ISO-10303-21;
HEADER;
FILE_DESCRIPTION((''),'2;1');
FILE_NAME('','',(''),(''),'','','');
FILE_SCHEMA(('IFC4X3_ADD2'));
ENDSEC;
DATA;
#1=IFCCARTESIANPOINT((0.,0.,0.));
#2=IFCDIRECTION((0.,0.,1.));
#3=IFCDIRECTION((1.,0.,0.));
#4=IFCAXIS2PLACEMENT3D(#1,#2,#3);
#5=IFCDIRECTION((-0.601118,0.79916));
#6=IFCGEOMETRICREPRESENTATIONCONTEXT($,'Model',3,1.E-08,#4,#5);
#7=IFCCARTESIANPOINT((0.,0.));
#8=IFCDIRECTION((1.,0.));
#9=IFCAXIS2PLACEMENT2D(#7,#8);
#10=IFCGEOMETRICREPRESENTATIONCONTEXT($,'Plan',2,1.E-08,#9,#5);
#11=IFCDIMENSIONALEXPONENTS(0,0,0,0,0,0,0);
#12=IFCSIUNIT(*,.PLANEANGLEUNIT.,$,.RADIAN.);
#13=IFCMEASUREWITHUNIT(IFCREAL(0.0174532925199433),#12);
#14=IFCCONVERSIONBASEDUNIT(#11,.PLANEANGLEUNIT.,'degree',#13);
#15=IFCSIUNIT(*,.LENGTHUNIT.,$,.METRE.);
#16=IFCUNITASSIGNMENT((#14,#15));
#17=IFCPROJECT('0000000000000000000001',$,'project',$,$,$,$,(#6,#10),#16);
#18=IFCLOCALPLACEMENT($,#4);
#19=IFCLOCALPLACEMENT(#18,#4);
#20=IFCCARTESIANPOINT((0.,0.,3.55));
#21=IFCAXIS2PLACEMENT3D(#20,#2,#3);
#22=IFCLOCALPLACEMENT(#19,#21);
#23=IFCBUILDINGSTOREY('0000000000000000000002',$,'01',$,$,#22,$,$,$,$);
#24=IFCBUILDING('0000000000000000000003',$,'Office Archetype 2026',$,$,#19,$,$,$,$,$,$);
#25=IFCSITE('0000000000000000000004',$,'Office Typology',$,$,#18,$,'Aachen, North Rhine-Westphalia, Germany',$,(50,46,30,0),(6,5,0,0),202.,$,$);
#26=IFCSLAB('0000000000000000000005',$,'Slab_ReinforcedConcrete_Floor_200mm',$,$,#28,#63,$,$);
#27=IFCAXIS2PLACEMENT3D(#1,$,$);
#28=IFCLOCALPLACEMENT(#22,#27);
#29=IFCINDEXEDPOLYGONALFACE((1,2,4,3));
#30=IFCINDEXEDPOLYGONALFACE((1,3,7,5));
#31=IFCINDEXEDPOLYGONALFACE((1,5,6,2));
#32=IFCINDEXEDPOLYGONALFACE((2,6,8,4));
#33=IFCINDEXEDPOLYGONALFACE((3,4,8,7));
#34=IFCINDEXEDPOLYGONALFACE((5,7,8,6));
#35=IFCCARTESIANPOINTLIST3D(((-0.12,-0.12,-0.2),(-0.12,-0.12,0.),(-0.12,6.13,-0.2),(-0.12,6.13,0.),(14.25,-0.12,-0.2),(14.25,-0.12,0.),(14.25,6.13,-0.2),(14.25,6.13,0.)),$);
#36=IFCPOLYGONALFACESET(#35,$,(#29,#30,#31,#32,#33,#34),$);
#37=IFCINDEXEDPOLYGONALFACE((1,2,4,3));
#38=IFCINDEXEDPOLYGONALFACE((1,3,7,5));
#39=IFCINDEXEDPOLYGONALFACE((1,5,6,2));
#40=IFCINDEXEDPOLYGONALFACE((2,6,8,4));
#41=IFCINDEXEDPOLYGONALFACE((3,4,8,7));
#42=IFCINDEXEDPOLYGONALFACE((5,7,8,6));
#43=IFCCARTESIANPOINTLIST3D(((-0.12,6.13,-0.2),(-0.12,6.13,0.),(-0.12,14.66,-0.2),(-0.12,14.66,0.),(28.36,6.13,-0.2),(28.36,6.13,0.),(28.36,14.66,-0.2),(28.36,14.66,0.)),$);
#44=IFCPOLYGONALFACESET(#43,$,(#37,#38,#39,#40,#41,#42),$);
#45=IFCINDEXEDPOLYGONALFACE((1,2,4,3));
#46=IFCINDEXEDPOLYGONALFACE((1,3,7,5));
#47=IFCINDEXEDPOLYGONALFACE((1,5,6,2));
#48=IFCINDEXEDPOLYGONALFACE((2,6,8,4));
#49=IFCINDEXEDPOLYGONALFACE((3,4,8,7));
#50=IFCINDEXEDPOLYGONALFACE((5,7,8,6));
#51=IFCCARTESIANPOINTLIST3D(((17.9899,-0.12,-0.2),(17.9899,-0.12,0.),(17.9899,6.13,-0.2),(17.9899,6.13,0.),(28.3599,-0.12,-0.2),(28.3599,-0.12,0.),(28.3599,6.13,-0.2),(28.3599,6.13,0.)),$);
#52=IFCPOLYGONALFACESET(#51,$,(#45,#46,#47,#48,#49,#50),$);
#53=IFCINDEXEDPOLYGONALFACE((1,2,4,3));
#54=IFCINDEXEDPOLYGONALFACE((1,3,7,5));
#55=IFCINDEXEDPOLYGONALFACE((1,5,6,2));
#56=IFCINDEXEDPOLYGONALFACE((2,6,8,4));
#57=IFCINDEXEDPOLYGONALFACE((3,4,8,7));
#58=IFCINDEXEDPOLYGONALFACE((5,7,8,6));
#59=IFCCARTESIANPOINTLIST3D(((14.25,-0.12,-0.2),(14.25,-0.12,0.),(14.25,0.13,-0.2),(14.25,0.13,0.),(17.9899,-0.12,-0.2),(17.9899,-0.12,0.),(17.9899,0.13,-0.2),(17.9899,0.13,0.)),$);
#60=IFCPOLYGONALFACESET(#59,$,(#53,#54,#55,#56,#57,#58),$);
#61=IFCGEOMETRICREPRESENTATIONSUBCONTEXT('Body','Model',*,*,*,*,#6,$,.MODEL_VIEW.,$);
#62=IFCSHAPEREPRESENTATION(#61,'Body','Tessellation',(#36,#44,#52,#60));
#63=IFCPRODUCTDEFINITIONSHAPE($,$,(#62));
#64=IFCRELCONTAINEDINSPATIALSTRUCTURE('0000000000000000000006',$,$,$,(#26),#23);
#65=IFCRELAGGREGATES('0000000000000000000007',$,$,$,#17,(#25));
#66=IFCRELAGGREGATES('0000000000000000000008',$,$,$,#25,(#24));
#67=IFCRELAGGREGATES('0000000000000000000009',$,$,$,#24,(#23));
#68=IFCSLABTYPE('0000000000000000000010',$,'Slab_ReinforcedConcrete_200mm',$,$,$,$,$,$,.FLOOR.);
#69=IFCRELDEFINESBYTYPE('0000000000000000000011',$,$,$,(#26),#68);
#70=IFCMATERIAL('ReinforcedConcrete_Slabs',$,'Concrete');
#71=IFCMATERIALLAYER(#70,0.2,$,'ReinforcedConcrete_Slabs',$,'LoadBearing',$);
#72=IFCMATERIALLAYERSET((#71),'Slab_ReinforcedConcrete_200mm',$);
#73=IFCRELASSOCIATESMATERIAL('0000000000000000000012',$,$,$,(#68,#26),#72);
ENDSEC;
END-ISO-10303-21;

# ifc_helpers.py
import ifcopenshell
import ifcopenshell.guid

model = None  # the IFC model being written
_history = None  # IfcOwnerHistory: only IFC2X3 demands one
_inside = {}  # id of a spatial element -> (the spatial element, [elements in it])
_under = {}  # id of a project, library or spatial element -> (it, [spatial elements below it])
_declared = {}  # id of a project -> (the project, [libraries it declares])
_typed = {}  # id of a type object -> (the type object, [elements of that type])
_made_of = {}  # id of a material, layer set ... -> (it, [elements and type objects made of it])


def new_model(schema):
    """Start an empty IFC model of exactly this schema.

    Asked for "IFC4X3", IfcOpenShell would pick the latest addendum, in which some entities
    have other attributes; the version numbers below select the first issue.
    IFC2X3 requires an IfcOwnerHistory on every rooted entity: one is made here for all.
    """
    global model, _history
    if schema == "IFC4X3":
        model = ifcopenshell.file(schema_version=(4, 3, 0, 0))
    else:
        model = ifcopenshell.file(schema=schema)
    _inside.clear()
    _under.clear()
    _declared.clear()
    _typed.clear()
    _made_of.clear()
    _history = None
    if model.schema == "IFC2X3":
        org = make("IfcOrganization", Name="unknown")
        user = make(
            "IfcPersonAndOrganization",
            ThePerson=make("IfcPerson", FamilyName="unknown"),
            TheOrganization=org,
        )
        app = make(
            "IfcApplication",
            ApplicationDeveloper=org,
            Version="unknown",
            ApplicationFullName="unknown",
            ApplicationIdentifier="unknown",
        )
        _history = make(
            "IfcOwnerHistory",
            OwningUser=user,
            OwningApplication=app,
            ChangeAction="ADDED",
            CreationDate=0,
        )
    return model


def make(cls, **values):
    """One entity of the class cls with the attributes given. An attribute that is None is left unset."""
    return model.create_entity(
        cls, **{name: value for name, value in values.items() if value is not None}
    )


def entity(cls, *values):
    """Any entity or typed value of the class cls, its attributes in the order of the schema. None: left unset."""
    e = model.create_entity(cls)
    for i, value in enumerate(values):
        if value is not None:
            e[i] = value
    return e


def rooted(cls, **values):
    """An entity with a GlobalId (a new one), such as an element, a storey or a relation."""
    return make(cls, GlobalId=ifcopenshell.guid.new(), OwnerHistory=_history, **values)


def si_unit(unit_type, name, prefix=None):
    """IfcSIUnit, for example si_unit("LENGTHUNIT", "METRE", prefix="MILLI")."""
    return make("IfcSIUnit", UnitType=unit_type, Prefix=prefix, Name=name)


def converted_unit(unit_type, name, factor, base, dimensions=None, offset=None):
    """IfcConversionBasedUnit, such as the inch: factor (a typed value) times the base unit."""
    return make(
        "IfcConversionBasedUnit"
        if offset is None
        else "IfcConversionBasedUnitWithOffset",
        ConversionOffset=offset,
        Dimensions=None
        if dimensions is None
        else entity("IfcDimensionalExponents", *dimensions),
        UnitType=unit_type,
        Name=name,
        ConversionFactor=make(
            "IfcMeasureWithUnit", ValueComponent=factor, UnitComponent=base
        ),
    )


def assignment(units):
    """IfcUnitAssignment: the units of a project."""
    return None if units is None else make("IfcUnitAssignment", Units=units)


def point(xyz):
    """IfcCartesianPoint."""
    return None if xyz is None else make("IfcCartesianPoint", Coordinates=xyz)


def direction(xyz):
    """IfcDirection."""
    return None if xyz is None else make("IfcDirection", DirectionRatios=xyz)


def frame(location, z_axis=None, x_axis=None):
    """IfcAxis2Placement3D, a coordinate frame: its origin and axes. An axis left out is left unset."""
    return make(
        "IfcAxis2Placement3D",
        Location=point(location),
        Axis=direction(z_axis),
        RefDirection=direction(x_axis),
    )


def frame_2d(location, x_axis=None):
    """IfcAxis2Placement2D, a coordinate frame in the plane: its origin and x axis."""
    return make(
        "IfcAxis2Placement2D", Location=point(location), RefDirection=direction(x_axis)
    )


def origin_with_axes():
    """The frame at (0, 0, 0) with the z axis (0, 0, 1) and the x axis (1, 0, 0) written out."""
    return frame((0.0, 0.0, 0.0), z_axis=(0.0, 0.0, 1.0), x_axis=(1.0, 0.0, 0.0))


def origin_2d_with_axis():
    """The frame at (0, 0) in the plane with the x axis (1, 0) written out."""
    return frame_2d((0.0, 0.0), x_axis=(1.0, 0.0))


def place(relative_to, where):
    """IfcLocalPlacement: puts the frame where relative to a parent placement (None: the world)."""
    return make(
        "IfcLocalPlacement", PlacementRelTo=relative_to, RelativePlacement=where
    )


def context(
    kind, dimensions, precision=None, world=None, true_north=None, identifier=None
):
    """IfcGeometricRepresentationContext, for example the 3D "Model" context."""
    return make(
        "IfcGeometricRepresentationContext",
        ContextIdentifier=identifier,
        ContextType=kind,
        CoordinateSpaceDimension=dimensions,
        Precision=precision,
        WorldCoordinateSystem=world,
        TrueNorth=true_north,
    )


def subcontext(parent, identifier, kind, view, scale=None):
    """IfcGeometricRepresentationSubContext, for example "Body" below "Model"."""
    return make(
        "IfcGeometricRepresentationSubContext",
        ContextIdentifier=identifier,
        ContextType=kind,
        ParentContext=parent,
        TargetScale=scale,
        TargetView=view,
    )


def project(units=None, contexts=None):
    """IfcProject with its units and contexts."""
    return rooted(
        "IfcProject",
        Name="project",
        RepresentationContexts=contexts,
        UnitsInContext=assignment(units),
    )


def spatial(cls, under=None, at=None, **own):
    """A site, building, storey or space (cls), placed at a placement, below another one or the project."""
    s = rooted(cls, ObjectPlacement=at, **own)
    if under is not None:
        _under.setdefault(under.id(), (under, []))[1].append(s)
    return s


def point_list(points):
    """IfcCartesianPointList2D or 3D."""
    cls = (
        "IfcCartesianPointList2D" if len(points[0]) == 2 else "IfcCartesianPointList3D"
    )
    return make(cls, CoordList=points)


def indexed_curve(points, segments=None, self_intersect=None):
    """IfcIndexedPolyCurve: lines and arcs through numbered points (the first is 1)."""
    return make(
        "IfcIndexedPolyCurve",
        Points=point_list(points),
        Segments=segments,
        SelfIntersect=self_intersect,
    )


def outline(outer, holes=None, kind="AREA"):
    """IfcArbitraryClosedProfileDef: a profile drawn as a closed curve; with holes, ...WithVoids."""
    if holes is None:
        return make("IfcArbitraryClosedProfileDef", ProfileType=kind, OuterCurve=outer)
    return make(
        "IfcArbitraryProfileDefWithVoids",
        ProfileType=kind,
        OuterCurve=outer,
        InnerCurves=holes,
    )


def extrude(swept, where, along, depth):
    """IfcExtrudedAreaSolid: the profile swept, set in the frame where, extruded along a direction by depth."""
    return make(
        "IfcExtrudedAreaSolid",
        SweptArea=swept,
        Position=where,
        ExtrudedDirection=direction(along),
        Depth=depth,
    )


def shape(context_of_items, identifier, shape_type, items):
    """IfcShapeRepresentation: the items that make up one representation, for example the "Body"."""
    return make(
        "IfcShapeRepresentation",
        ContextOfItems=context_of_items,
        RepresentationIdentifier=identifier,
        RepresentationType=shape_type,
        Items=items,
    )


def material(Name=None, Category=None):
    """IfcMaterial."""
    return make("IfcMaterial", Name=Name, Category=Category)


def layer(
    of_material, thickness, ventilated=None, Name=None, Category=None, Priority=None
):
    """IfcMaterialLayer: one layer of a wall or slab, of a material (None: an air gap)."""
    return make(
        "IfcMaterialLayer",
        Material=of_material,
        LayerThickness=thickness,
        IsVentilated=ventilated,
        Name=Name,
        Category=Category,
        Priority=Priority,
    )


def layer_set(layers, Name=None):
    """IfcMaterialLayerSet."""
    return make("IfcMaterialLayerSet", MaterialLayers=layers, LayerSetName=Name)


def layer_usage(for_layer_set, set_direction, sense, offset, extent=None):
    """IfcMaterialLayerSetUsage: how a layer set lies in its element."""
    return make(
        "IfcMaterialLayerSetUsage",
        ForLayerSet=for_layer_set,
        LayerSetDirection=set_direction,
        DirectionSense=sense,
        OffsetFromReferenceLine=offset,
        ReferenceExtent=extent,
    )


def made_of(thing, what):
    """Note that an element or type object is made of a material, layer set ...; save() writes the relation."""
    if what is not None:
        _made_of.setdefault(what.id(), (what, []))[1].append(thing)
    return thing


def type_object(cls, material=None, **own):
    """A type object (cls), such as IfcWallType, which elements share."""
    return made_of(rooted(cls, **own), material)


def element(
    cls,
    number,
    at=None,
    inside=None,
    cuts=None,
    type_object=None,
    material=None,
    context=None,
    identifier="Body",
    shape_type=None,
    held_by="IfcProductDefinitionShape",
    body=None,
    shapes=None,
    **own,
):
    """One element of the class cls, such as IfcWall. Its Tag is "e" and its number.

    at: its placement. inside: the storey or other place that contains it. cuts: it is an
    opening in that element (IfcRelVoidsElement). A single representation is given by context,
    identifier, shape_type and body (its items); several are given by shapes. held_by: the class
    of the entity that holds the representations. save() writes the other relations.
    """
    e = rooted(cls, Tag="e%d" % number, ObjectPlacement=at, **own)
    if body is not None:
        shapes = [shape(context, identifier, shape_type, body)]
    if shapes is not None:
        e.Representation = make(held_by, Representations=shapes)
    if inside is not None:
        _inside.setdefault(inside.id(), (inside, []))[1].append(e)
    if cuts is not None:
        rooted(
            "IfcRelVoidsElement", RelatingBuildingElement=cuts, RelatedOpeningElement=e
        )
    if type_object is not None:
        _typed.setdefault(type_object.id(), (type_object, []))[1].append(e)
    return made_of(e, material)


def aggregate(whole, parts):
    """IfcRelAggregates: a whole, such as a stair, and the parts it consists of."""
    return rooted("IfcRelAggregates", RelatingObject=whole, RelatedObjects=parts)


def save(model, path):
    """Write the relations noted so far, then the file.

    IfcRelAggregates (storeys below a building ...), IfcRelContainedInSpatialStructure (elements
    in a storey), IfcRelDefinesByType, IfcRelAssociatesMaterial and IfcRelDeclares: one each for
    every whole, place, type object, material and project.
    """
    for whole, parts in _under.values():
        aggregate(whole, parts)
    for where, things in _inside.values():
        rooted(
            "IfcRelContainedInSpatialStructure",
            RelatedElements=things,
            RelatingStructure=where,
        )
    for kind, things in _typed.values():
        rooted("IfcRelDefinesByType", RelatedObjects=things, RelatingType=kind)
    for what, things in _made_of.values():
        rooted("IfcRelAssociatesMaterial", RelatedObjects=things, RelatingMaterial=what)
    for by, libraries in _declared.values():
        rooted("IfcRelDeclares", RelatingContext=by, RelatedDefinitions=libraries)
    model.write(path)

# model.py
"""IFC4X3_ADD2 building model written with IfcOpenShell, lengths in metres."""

from ifc_helpers import new_model, entity, si_unit, converted_unit, direction, frame, origin_with_axes, origin_2d_with_axis, place, context, subcontext, project, spatial, indexed_curve, outline, extrude, material, layer, layer_set, layer_usage, type_object, element, save


model = new_model("IFC4X3_ADD2")

# Units and contexts
model_context = context("Model", 3, precision=1e-08, world=origin_with_axes(), true_north=direction((-0.601118, 0.79916)))
plan_context = context("Plan", 2, precision=1e-08, world=origin_2d_with_axis(), true_north=direction((-0.601118, 0.79916)))
body_context = subcontext(model_context, "Body", "Model", "MODEL_VIEW")
ifc_project = project(units=[converted_unit("PLANEANGLEUNIT", "degree", entity("IfcReal", 0.0174532925199433), si_unit("PLANEANGLEUNIT", "RADIAN"), dimensions=[0, 0, 0, 0, 0, 0, 0]), si_unit("LENGTHUNIT", "METRE")], contexts=[model_context, plan_context])

# Site, building, storey
site_placement = place(None, origin_with_axes())
site = spatial("IfcSite", under=ifc_project, at=site_placement, Name="Office Typology", LongName="Aachen, North Rhine-Westphalia, Germany", RefLatitude=(50, 46, 30, 0), RefLongitude=(6, 5, 0, 0), RefElevation=202.0)
building_placement = place(site_placement, origin_with_axes())
building = spatial("IfcBuilding", under=site, at=building_placement, Name="Office Archetype 2026")
storey_placement = place(building_placement, frame((0.0, 0.0, 3.55), z_axis=(0.0, 0.0, 1.0), x_axis=(1.0, 0.0, 0.0)))
storey = spatial("IfcBuildingStorey", under=building, at=storey_placement, Name="01")

# Slab
ifc_material_1 = material(Name="ReinforcedConcrete_Slabs", Category="Concrete")
ifc_layer_1 = layer(ifc_material_1, 0.2, Name="ReinforcedConcrete_Slabs", Category="LoadBearing")
ifc_layer_set_1 = layer_set([ifc_layer_1], Name="Slab_ReinforcedConcrete_200mm")
slab_type_1 = type_object("IfcSlabType", Name="Slab_ReinforcedConcrete_200mm", PredefinedType="FLOOR", material=ifc_layer_set_1)
ifc_layer_usage_1 = layer_usage(ifc_layer_set_1, "AXIS3", "POSITIVE", 0.0)
slab_1_placement = place(storey_placement, frame((17.9899, 6.13, 0.0), z_axis=(0.0, 0.0, 1.0), x_axis=(1.0, 0.0, 0.0)))
element("IfcSlab", 1, at=slab_1_placement, inside=storey, type_object=slab_type_1, material=ifc_layer_usage_1, Name="Slab_ReinforcedConcrete_Floor_200mm", context=body_context, shape_type="SweptSolid", body=[
    extrude(outline(indexed_curve([(0.0, -6.25), (14.37, -6.25), (14.37, 0.0), (0.0, 0.0), (0.0, -6.25)])), frame((-18.1099, 0.0, -0.2), z_axis=(0.0, 0.0, 1.0), x_axis=(1.0, 0.0, 0.0)), (0.0, 0.0, 1.0), 0.2),
    extrude(outline(indexed_curve([(0.0, 0.0), (28.48, 0.0), (28.48, -8.53), (0.0, -8.53), (0.0, 0.0)])), frame((-18.1099, 8.53, -0.2), z_axis=(0.0, 0.0, 1.0), x_axis=(1.0, 0.0, 0.0)), (0.0, 0.0, 1.0), 0.2),
    extrude(outline(indexed_curve([(0.0, 0.0), (0.0, -6.25), (10.37, -6.25), (10.37, 0.0), (0.0, 0.0)])), frame((0.0, 0.0, -0.2), z_axis=(0.0, 0.0, 1.0), x_axis=(1.0, 0.0, 0.0)), (0.0, 0.0, 1.0), 0.2),
    extrude(outline(indexed_curve([(0.0, 0.0), (3.7399, 0.0), (3.7399, 0.25), (0.0, 0.25), (0.0, 0.0)])), frame((-3.7399, -6.25, -0.2), z_axis=(0.0, 0.0, 1.0), x_axis=(1.0, 0.0, 0.0)), (0.0, 0.0, 1.0), 0.2),
])

save(model, "model.ifc")
